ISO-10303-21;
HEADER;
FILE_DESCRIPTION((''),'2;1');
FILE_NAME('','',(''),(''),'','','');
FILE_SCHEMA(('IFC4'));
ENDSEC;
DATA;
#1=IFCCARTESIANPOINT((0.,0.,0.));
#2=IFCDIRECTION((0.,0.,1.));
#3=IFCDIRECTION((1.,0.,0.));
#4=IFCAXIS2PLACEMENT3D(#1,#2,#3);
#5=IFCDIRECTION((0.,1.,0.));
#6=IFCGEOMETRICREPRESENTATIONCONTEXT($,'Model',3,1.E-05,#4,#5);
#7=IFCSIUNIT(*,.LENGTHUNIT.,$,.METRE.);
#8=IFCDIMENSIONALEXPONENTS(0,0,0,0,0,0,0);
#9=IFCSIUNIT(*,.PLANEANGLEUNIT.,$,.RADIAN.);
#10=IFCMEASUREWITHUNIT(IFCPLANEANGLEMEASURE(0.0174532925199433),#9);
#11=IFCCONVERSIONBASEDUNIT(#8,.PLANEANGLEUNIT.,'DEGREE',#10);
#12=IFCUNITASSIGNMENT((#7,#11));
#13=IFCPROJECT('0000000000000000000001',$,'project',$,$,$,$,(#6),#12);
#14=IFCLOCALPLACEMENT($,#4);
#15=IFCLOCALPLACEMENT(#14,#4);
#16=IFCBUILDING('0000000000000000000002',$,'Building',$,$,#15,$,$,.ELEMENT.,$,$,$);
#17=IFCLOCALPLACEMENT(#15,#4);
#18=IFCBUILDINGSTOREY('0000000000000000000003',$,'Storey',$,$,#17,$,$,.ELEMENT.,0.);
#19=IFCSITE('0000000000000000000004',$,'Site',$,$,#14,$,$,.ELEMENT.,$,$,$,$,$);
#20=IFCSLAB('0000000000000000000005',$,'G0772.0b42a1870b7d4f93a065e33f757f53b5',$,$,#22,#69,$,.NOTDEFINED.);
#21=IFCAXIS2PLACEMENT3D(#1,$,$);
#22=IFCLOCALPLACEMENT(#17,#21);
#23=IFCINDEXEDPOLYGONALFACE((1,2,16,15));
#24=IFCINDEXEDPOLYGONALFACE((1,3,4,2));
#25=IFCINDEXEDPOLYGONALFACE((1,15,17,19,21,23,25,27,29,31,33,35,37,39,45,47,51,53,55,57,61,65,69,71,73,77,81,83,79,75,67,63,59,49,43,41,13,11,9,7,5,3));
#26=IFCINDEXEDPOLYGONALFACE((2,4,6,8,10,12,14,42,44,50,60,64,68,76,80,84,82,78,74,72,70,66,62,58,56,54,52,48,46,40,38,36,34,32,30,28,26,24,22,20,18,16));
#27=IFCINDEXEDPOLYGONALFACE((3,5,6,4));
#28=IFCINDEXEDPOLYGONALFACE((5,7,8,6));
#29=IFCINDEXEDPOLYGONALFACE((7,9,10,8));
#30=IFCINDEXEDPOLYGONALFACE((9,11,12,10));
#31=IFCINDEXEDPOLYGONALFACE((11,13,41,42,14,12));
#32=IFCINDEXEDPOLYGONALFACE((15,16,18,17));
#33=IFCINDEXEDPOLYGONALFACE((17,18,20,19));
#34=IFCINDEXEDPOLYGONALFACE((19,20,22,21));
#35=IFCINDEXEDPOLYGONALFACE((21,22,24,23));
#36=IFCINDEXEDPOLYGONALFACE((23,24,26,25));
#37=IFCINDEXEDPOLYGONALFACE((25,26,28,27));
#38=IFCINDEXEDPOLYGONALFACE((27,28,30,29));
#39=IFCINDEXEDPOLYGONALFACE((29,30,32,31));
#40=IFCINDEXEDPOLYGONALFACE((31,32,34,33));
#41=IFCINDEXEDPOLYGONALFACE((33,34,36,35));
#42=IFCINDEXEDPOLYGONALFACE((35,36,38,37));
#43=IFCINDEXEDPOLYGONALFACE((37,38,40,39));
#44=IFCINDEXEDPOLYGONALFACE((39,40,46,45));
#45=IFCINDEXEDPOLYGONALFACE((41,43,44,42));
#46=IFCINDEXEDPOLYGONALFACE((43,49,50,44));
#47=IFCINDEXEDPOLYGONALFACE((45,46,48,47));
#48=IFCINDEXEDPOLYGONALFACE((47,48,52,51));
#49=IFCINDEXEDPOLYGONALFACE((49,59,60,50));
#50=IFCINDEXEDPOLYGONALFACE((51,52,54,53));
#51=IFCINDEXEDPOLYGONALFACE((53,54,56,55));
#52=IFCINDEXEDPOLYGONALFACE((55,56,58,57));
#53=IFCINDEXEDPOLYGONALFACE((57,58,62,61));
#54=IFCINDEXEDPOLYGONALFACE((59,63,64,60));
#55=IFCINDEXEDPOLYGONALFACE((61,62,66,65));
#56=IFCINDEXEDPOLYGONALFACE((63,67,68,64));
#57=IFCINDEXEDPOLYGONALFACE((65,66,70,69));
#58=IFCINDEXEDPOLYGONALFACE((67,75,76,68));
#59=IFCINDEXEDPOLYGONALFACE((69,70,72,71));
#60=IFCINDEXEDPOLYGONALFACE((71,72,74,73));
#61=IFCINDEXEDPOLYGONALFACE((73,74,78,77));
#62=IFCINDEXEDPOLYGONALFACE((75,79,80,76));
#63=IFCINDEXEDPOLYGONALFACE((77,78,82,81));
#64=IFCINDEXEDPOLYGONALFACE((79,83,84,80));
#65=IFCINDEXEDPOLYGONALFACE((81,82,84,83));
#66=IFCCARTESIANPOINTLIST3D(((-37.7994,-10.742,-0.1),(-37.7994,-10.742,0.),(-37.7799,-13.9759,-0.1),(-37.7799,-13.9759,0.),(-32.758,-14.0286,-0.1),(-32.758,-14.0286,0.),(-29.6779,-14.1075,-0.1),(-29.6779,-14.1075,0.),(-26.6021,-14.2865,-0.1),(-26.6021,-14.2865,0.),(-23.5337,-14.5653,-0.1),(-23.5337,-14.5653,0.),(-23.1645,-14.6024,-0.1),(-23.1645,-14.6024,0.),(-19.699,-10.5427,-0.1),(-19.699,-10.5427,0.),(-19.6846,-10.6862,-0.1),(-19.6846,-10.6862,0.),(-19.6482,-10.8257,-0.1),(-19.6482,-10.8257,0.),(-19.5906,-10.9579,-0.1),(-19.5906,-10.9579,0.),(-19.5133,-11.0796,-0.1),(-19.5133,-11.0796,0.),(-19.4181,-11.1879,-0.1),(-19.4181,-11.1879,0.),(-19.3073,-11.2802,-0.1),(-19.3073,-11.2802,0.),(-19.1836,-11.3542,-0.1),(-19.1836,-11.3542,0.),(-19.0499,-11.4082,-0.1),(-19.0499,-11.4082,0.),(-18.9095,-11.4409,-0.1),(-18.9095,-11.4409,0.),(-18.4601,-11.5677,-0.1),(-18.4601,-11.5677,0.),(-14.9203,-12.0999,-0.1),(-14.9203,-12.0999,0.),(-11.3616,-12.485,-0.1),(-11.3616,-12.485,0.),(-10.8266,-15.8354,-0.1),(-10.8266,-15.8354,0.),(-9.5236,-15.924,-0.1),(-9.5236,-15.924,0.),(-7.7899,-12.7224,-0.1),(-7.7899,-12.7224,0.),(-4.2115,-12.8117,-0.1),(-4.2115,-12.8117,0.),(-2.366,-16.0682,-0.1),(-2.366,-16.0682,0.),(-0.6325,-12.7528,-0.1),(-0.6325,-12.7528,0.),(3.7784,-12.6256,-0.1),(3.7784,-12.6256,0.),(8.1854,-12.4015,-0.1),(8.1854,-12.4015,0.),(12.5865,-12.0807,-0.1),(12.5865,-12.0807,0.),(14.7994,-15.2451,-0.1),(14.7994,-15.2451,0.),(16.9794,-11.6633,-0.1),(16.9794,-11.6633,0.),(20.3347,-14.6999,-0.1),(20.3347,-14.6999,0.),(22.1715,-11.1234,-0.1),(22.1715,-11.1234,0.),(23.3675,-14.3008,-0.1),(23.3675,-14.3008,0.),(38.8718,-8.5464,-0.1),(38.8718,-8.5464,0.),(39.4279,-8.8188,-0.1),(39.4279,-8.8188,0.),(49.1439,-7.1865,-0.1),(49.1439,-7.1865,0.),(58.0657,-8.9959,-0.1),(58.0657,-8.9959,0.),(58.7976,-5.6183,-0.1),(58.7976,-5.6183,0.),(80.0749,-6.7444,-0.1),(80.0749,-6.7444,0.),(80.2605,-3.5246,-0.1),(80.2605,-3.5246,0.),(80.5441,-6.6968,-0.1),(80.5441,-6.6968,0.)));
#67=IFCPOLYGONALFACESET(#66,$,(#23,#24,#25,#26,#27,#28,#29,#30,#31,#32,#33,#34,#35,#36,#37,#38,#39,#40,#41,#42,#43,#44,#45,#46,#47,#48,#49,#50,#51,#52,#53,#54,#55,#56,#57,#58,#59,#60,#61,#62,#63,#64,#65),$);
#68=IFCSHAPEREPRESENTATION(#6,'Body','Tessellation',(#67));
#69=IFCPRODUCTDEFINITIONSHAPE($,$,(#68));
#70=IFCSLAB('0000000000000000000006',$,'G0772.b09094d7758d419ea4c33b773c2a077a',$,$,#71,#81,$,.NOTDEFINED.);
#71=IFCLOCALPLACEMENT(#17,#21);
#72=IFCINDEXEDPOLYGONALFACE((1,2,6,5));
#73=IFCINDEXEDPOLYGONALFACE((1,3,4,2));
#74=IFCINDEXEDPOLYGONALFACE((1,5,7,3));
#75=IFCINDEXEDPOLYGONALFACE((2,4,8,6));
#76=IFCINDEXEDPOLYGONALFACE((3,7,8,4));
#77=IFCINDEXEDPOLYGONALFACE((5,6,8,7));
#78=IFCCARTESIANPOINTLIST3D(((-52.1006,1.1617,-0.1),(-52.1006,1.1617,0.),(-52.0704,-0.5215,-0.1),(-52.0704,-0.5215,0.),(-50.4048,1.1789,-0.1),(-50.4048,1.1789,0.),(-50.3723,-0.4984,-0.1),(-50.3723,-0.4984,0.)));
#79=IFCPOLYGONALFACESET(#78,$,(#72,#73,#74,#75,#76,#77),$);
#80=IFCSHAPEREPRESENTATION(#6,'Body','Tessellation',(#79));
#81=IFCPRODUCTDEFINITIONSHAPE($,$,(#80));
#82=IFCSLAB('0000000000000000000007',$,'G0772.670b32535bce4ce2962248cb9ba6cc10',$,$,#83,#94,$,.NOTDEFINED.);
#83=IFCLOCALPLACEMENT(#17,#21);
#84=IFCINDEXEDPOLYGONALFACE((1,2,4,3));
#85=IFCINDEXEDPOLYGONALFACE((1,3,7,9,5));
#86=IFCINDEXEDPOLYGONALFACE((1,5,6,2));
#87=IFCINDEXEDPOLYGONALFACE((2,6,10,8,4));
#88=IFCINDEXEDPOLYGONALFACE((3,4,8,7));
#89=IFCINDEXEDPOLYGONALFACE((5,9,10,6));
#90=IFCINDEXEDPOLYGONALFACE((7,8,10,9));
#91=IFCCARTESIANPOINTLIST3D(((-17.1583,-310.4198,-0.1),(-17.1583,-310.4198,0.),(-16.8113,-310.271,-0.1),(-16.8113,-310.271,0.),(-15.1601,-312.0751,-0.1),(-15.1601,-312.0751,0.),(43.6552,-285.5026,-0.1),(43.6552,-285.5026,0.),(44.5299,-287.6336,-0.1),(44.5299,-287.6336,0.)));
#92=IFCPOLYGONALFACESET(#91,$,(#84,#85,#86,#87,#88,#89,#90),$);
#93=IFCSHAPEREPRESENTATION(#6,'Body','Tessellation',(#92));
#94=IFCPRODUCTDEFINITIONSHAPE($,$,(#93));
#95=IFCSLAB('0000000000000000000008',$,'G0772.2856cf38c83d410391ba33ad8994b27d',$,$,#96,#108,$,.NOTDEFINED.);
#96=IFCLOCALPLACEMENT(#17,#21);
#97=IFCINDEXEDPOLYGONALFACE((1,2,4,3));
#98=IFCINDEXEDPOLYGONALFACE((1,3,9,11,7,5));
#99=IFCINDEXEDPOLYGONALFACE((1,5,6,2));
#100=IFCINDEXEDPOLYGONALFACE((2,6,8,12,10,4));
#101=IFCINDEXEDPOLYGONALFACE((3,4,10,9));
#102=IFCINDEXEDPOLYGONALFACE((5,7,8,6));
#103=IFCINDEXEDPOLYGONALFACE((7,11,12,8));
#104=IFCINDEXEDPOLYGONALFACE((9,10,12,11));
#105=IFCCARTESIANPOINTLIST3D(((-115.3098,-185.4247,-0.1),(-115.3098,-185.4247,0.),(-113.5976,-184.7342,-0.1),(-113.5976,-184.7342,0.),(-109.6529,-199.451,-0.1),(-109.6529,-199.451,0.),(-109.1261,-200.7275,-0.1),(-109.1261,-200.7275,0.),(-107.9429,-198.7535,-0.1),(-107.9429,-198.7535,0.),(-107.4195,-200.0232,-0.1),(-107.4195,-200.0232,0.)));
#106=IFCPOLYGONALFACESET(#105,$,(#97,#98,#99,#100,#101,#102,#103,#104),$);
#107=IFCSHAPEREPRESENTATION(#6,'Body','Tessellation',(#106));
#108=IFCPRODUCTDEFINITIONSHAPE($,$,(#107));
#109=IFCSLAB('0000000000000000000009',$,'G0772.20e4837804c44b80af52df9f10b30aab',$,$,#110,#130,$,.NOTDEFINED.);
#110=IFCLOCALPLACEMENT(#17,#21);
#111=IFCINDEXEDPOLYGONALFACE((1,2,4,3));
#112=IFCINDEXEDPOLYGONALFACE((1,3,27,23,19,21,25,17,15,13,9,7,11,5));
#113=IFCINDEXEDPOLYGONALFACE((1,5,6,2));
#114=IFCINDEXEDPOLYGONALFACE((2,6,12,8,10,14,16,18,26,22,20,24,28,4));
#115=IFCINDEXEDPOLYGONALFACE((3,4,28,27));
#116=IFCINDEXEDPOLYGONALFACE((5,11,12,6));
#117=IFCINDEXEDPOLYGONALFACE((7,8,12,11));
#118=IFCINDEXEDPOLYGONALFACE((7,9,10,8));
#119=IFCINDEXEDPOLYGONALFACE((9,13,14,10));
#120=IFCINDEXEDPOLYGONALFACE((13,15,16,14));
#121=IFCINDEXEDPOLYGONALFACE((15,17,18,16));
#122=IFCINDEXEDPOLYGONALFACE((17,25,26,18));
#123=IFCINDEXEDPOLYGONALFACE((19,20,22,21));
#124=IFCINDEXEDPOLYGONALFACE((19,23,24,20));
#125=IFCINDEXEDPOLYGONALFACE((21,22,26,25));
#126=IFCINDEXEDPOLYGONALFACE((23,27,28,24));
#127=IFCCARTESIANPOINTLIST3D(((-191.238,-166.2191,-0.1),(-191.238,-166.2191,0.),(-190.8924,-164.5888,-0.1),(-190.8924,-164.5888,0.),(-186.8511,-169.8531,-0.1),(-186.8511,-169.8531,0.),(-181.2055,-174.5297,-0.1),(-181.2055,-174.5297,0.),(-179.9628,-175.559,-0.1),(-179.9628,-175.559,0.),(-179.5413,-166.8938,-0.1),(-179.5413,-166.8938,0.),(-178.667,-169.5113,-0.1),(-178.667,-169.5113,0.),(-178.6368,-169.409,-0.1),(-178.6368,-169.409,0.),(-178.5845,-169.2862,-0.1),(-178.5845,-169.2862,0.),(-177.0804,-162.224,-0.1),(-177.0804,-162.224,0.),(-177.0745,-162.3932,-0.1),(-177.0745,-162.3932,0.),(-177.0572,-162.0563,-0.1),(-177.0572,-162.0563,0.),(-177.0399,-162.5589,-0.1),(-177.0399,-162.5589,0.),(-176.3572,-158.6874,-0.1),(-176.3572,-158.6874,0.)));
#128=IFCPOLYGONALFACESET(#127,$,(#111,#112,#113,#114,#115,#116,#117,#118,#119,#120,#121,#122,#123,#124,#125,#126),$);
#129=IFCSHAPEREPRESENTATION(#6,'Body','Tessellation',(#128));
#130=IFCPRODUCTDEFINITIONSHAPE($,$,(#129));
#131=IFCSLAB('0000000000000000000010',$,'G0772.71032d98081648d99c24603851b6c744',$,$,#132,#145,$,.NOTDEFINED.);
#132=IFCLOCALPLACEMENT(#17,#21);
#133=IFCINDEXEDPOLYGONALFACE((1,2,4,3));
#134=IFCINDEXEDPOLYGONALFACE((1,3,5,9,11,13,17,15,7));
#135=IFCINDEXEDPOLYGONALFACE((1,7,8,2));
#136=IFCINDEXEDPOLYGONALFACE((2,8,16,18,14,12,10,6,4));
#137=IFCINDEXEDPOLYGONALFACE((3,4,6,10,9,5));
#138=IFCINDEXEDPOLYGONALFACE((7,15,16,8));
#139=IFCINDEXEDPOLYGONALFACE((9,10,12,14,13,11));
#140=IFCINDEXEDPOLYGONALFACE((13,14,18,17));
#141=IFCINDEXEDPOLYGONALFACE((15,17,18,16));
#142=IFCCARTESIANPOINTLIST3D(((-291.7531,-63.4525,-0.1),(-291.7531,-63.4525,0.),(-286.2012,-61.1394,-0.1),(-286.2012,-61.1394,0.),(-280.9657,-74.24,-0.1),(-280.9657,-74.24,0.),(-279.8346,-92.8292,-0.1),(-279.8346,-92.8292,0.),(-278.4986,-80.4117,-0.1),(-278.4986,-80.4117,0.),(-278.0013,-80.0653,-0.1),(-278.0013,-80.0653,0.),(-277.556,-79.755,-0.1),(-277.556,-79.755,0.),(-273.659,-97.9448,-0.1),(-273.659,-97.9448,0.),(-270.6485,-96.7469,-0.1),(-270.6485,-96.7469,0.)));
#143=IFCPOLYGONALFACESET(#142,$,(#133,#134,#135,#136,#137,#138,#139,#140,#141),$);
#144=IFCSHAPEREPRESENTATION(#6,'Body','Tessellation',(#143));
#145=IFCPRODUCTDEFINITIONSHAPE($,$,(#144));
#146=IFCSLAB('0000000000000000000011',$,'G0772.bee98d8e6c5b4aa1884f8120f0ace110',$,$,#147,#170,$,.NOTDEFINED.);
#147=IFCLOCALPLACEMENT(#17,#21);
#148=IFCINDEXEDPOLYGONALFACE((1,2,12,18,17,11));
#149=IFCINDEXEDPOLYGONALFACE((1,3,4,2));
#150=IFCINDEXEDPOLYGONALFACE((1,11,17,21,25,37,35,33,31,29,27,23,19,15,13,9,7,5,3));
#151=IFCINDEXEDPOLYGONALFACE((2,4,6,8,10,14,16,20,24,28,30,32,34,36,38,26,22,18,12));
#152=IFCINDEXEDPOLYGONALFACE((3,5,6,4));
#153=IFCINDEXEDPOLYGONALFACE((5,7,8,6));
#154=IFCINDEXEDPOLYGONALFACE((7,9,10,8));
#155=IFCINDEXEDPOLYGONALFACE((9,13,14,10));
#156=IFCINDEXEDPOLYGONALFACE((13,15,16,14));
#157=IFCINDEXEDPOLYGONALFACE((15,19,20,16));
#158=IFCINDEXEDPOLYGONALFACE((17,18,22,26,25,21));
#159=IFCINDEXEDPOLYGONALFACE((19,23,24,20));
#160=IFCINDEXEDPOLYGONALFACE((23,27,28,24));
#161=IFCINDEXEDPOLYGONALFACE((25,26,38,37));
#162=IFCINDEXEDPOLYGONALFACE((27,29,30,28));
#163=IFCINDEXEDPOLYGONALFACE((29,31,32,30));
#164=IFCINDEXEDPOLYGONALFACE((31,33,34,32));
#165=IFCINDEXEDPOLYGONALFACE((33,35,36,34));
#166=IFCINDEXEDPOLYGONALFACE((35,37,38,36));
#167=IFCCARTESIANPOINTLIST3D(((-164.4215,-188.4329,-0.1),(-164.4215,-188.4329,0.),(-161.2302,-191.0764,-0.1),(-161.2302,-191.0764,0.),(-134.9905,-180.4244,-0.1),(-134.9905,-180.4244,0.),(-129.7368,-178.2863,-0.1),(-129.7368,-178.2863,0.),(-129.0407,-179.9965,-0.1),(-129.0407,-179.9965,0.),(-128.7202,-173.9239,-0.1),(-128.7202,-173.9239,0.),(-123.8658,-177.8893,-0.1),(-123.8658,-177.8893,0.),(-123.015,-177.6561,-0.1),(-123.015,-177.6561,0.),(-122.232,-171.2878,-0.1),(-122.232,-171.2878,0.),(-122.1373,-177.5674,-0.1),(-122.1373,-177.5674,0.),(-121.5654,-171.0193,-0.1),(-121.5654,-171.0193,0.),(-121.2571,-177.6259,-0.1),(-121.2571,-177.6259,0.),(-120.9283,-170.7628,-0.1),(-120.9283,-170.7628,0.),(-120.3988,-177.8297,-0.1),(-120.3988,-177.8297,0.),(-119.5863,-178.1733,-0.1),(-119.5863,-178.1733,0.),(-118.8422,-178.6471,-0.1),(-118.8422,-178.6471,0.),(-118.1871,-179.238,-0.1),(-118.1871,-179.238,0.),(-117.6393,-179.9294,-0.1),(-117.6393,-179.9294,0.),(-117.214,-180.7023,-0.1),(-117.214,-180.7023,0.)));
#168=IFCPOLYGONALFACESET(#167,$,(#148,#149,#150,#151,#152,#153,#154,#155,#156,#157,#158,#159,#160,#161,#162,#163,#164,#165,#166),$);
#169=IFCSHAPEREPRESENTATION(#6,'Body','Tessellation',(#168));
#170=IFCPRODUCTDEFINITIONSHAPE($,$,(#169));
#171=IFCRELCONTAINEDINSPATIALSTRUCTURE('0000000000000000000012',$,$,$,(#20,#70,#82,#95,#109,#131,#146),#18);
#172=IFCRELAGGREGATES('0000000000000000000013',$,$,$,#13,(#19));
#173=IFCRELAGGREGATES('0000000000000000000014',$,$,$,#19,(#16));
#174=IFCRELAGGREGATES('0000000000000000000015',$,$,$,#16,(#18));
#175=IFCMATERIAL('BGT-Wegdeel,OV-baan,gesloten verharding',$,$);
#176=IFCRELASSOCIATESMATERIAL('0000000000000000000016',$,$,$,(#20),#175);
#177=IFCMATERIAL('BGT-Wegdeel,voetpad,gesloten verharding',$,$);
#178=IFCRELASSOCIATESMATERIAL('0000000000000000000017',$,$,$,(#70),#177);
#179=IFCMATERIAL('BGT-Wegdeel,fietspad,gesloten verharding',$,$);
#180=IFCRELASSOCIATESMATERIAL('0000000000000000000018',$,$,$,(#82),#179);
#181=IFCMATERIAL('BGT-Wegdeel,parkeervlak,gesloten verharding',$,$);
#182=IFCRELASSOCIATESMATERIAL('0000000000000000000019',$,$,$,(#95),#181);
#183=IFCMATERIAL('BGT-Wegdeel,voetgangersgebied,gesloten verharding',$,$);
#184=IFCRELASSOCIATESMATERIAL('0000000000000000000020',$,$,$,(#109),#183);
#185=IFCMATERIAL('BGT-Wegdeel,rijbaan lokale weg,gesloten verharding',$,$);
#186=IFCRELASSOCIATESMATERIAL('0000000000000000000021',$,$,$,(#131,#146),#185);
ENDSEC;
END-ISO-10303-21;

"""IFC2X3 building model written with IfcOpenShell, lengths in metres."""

from ifc_helpers import new_model, entity, si_unit, converted_unit, direction, frame, origin_with_axes, place, context, project, spatial, polyline, outline, extrude, material, element, save


model = new_model("IFC2X3")

# Units and contexts
model_context = context("Model", 3, precision=1e-05, world=origin_with_axes(), true_north=direction((0.0, 1.0, 0.0)))
ifc_project = project(units=[si_unit("LENGTHUNIT", "METRE"), converted_unit("PLANEANGLEUNIT", "DEGREE", entity("IfcPlaneAngleMeasure", 0.0174532925199433), si_unit("PLANEANGLEUNIT", "RADIAN"), dimensions=[0, 0, 0, 0, 0, 0, 0])], contexts=[model_context])

# Site, building, storey
site_placement = place(None, origin_with_axes())
site = spatial("IfcSite", under=ifc_project, at=site_placement, Name="Site", CompositionType="ELEMENT")
building_placement = place(site_placement, origin_with_axes())
building = spatial("IfcBuilding", under=site, at=building_placement, Name="Building", CompositionType="ELEMENT")
storey_placement = place(building_placement, origin_with_axes())
storey = spatial("IfcBuildingStorey", under=building, at=storey_placement, Name="Storey", CompositionType="ELEMENT", Elevation=0.0)

# Slabs
ifc_material_1 = material(Name="BGT-Wegdeel,voetgangersgebied,gesloten verharding")
ifc_material_2 = material(Name="BGT-Wegdeel,voetpad,gesloten verharding")
ifc_material_3 = material(Name="BGT-Wegdeel,parkeervlak,gesloten verharding")
ifc_material_4 = material(Name="BGT-Wegdeel,rijbaan lokale weg,gesloten verharding")
ifc_material_5 = material(Name="BGT-Wegdeel,OV-baan,gesloten verharding")
slab_1_placement = place(storey_placement, frame((0.0, 0.0, -0.1), z_axis=(0.0, 0.0, 1.0), x_axis=(1.0, 0.0, 0.0)))
element("IfcSlab", 1, at=slab_1_placement, inside=storey, material=ifc_material_5, Name="G0772.0b42a1870b7d4f93a065e33f757f53b5", PredefinedType="NOTDEFINED", context=model_context, shape_type="SweptSolid", body=[
    extrude(outline(polyline([(80.2605, -3.5246), (80.5441, -6.6968), (80.0749, -6.7444), (58.0657, -8.9959), (23.3675, -14.3008), (20.3347, -14.6999), (14.7994, -15.2451), (-2.366, -16.0682), (-9.5236, -15.924), (-10.8266, -15.8354), (-23.1645, -14.6024), (-23.5337, -14.5653), (-26.6021, -14.2865), (-29.6779, -14.1075), (-32.758, -14.0286), (-37.7799, -13.9759), (-37.7994, -10.742), (-19.699, -10.5427), (-19.6846, -10.6862), (-19.6482, -10.8257), (-19.5906, -10.9579), (-19.5133, -11.0796), (-19.4181, -11.1879), (-19.3073, -11.2802), (-19.1836, -11.3542), (-19.0499, -11.4082), (-18.9095, -11.4409), (-18.4601, -11.5677), (-14.9203, -12.0999), (-11.3616, -12.485), (-7.7899, -12.7224), (-4.2115, -12.8117), (-0.6325, -12.7528), (3.7784, -12.6256), (8.1854, -12.4015), (12.5865, -12.0807), (16.9794, -11.6633), (22.1715, -11.1234), (38.8718, -8.5464), (39.4279, -8.8188), (49.1439, -7.1865), (58.7976, -5.6183), (80.2605, -3.5246)])), origin_with_axes(), (0.0, 0.0, 1.0), 0.1),
])
slab_2_placement = place(storey_placement, frame((0.0, 0.0, -0.1), z_axis=(0.0, 0.0, 1.0), x_axis=(1.0, 0.0, 0.0)))
element("IfcSlab", 2, at=slab_2_placement, inside=storey, material=ifc_material_2, Name="G0772.b09094d7758d419ea4c33b773c2a077a", PredefinedType="NOTDEFINED", context=model_context, shape_type="SweptSolid", body=[
    extrude(outline(polyline([(-50.3723, -0.4984), (-52.0704, -0.5215), (-52.1006, 1.1617), (-50.4048, 1.1789), (-50.3723, -0.4984)])), origin_with_axes(), (0.0, 0.0, 1.0), 0.1),
])
ifc_material_6 = material(Name="BGT-Wegdeel,fietspad,gesloten verharding")
slab_3_placement = place(storey_placement, frame((0.0, 0.0, -0.1), z_axis=(0.0, 0.0, 1.0), x_axis=(1.0, 0.0, 0.0)))
element("IfcSlab", 3, at=slab_3_placement, inside=storey, material=ifc_material_6, Name="G0772.670b32535bce4ce2962248cb9ba6cc10", PredefinedType="NOTDEFINED", context=model_context, shape_type="SweptSolid", body=[
    extrude(outline(polyline([(-16.8113, -310.271), (43.6552, -285.5026), (44.5299, -287.6336), (-15.1601, -312.0751), (-17.1583, -310.4198), (-16.8113, -310.271)])), origin_with_axes(), (0.0, 0.0, 1.0), 0.1),
])
slab_4_placement = place(storey_placement, frame((0.0, 0.0, -0.1), z_axis=(0.0, 0.0, 1.0), x_axis=(1.0, 0.0, 0.0)))
element("IfcSlab", 4, at=slab_4_placement, inside=storey, material=ifc_material_3, Name="G0772.2856cf38c83d410391ba33ad8994b27d", PredefinedType="NOTDEFINED", context=model_context, shape_type="SweptSolid", body=[
    extrude(outline(polyline([(-113.5976, -184.7342), (-107.9429, -198.7535), (-107.4195, -200.0232), (-109.1261, -200.7275), (-109.6529, -199.451), (-115.3098, -185.4247), (-113.5976, -184.7342)])), origin_with_axes(), (0.0, 0.0, 1.0), 0.1),
])
slab_5_placement = place(storey_placement, frame((0.0, 0.0, -0.1), z_axis=(0.0, 0.0, 1.0), x_axis=(1.0, 0.0, 0.0)))
element("IfcSlab", 5, at=slab_5_placement, inside=storey, material=ifc_material_1, Name="G0772.20e4837804c44b80af52df9f10b30aab", PredefinedType="NOTDEFINED", context=model_context, shape_type="SweptSolid", body=[
    extrude(outline(polyline([(-190.8924, -164.5888), (-176.3572, -158.6874), (-177.0572, -162.0563), (-177.0804, -162.224), (-177.0745, -162.3932), (-177.0399, -162.5589), (-178.5845, -169.2862), (-178.6368, -169.409), (-178.667, -169.5113), (-179.9628, -175.559), (-181.2055, -174.5297), (-179.5413, -166.8938), (-186.8511, -169.8531), (-191.238, -166.2191), (-190.8924, -164.5888)])), origin_with_axes(), (0.0, 0.0, 1.0), 0.1),
])
slab_6_placement = place(storey_placement, frame((0.0, 0.0, -0.1), z_axis=(0.0, 0.0, 1.0), x_axis=(1.0, 0.0, 0.0)))
element("IfcSlab", 6, at=slab_6_placement, inside=storey, material=ifc_material_4, Name="G0772.71032d98081648d99c24603851b6c744", PredefinedType="NOTDEFINED", context=model_context, shape_type="SweptSolid", body=[
    extrude(outline(polyline([(-291.7531, -63.4525), (-286.2012, -61.1394), (-280.9657, -74.24), (-278.4986, -80.4117), (-278.0013, -80.0653), (-277.556, -79.755), (-270.6485, -96.7469), (-273.659, -97.9448), (-279.8346, -92.8292), (-291.7531, -63.4525)])), origin_with_axes(), (0.0, 0.0, 1.0), 0.1),
])
slab_7_placement = place(storey_placement, frame((0.0, 0.0, -0.1), z_axis=(0.0, 0.0, 1.0), x_axis=(1.0, 0.0, 0.0)))
element("IfcSlab", 7, at=slab_7_placement, inside=storey, material=ifc_material_4, Name="G0772.bee98d8e6c5b4aa1884f8120f0ace110", PredefinedType="NOTDEFINED", context=model_context, shape_type="SweptSolid", body=[
    extrude(outline(polyline([(-128.7202, -173.9239), (-122.232, -171.2878), (-121.5654, -171.0193), (-120.9283, -170.7628), (-117.214, -180.7023), (-117.6393, -179.9294), (-118.1871, -179.238), (-118.8422, -178.6471), (-119.5863, -178.1733), (-120.3988, -177.8297), (-121.2571, -177.6259), (-122.1373, -177.5674), (-123.015, -177.6561), (-123.8658, -177.8893), (-129.0407, -179.9965), (-129.7368, -178.2863), (-134.9905, -180.4244), (-161.2302, -191.0764), (-164.4215, -188.4329), (-128.7202, -173.9239)])), origin_with_axes(), (0.0, 0.0, 1.0), 0.1),
])

save(model, "model.ifc")
